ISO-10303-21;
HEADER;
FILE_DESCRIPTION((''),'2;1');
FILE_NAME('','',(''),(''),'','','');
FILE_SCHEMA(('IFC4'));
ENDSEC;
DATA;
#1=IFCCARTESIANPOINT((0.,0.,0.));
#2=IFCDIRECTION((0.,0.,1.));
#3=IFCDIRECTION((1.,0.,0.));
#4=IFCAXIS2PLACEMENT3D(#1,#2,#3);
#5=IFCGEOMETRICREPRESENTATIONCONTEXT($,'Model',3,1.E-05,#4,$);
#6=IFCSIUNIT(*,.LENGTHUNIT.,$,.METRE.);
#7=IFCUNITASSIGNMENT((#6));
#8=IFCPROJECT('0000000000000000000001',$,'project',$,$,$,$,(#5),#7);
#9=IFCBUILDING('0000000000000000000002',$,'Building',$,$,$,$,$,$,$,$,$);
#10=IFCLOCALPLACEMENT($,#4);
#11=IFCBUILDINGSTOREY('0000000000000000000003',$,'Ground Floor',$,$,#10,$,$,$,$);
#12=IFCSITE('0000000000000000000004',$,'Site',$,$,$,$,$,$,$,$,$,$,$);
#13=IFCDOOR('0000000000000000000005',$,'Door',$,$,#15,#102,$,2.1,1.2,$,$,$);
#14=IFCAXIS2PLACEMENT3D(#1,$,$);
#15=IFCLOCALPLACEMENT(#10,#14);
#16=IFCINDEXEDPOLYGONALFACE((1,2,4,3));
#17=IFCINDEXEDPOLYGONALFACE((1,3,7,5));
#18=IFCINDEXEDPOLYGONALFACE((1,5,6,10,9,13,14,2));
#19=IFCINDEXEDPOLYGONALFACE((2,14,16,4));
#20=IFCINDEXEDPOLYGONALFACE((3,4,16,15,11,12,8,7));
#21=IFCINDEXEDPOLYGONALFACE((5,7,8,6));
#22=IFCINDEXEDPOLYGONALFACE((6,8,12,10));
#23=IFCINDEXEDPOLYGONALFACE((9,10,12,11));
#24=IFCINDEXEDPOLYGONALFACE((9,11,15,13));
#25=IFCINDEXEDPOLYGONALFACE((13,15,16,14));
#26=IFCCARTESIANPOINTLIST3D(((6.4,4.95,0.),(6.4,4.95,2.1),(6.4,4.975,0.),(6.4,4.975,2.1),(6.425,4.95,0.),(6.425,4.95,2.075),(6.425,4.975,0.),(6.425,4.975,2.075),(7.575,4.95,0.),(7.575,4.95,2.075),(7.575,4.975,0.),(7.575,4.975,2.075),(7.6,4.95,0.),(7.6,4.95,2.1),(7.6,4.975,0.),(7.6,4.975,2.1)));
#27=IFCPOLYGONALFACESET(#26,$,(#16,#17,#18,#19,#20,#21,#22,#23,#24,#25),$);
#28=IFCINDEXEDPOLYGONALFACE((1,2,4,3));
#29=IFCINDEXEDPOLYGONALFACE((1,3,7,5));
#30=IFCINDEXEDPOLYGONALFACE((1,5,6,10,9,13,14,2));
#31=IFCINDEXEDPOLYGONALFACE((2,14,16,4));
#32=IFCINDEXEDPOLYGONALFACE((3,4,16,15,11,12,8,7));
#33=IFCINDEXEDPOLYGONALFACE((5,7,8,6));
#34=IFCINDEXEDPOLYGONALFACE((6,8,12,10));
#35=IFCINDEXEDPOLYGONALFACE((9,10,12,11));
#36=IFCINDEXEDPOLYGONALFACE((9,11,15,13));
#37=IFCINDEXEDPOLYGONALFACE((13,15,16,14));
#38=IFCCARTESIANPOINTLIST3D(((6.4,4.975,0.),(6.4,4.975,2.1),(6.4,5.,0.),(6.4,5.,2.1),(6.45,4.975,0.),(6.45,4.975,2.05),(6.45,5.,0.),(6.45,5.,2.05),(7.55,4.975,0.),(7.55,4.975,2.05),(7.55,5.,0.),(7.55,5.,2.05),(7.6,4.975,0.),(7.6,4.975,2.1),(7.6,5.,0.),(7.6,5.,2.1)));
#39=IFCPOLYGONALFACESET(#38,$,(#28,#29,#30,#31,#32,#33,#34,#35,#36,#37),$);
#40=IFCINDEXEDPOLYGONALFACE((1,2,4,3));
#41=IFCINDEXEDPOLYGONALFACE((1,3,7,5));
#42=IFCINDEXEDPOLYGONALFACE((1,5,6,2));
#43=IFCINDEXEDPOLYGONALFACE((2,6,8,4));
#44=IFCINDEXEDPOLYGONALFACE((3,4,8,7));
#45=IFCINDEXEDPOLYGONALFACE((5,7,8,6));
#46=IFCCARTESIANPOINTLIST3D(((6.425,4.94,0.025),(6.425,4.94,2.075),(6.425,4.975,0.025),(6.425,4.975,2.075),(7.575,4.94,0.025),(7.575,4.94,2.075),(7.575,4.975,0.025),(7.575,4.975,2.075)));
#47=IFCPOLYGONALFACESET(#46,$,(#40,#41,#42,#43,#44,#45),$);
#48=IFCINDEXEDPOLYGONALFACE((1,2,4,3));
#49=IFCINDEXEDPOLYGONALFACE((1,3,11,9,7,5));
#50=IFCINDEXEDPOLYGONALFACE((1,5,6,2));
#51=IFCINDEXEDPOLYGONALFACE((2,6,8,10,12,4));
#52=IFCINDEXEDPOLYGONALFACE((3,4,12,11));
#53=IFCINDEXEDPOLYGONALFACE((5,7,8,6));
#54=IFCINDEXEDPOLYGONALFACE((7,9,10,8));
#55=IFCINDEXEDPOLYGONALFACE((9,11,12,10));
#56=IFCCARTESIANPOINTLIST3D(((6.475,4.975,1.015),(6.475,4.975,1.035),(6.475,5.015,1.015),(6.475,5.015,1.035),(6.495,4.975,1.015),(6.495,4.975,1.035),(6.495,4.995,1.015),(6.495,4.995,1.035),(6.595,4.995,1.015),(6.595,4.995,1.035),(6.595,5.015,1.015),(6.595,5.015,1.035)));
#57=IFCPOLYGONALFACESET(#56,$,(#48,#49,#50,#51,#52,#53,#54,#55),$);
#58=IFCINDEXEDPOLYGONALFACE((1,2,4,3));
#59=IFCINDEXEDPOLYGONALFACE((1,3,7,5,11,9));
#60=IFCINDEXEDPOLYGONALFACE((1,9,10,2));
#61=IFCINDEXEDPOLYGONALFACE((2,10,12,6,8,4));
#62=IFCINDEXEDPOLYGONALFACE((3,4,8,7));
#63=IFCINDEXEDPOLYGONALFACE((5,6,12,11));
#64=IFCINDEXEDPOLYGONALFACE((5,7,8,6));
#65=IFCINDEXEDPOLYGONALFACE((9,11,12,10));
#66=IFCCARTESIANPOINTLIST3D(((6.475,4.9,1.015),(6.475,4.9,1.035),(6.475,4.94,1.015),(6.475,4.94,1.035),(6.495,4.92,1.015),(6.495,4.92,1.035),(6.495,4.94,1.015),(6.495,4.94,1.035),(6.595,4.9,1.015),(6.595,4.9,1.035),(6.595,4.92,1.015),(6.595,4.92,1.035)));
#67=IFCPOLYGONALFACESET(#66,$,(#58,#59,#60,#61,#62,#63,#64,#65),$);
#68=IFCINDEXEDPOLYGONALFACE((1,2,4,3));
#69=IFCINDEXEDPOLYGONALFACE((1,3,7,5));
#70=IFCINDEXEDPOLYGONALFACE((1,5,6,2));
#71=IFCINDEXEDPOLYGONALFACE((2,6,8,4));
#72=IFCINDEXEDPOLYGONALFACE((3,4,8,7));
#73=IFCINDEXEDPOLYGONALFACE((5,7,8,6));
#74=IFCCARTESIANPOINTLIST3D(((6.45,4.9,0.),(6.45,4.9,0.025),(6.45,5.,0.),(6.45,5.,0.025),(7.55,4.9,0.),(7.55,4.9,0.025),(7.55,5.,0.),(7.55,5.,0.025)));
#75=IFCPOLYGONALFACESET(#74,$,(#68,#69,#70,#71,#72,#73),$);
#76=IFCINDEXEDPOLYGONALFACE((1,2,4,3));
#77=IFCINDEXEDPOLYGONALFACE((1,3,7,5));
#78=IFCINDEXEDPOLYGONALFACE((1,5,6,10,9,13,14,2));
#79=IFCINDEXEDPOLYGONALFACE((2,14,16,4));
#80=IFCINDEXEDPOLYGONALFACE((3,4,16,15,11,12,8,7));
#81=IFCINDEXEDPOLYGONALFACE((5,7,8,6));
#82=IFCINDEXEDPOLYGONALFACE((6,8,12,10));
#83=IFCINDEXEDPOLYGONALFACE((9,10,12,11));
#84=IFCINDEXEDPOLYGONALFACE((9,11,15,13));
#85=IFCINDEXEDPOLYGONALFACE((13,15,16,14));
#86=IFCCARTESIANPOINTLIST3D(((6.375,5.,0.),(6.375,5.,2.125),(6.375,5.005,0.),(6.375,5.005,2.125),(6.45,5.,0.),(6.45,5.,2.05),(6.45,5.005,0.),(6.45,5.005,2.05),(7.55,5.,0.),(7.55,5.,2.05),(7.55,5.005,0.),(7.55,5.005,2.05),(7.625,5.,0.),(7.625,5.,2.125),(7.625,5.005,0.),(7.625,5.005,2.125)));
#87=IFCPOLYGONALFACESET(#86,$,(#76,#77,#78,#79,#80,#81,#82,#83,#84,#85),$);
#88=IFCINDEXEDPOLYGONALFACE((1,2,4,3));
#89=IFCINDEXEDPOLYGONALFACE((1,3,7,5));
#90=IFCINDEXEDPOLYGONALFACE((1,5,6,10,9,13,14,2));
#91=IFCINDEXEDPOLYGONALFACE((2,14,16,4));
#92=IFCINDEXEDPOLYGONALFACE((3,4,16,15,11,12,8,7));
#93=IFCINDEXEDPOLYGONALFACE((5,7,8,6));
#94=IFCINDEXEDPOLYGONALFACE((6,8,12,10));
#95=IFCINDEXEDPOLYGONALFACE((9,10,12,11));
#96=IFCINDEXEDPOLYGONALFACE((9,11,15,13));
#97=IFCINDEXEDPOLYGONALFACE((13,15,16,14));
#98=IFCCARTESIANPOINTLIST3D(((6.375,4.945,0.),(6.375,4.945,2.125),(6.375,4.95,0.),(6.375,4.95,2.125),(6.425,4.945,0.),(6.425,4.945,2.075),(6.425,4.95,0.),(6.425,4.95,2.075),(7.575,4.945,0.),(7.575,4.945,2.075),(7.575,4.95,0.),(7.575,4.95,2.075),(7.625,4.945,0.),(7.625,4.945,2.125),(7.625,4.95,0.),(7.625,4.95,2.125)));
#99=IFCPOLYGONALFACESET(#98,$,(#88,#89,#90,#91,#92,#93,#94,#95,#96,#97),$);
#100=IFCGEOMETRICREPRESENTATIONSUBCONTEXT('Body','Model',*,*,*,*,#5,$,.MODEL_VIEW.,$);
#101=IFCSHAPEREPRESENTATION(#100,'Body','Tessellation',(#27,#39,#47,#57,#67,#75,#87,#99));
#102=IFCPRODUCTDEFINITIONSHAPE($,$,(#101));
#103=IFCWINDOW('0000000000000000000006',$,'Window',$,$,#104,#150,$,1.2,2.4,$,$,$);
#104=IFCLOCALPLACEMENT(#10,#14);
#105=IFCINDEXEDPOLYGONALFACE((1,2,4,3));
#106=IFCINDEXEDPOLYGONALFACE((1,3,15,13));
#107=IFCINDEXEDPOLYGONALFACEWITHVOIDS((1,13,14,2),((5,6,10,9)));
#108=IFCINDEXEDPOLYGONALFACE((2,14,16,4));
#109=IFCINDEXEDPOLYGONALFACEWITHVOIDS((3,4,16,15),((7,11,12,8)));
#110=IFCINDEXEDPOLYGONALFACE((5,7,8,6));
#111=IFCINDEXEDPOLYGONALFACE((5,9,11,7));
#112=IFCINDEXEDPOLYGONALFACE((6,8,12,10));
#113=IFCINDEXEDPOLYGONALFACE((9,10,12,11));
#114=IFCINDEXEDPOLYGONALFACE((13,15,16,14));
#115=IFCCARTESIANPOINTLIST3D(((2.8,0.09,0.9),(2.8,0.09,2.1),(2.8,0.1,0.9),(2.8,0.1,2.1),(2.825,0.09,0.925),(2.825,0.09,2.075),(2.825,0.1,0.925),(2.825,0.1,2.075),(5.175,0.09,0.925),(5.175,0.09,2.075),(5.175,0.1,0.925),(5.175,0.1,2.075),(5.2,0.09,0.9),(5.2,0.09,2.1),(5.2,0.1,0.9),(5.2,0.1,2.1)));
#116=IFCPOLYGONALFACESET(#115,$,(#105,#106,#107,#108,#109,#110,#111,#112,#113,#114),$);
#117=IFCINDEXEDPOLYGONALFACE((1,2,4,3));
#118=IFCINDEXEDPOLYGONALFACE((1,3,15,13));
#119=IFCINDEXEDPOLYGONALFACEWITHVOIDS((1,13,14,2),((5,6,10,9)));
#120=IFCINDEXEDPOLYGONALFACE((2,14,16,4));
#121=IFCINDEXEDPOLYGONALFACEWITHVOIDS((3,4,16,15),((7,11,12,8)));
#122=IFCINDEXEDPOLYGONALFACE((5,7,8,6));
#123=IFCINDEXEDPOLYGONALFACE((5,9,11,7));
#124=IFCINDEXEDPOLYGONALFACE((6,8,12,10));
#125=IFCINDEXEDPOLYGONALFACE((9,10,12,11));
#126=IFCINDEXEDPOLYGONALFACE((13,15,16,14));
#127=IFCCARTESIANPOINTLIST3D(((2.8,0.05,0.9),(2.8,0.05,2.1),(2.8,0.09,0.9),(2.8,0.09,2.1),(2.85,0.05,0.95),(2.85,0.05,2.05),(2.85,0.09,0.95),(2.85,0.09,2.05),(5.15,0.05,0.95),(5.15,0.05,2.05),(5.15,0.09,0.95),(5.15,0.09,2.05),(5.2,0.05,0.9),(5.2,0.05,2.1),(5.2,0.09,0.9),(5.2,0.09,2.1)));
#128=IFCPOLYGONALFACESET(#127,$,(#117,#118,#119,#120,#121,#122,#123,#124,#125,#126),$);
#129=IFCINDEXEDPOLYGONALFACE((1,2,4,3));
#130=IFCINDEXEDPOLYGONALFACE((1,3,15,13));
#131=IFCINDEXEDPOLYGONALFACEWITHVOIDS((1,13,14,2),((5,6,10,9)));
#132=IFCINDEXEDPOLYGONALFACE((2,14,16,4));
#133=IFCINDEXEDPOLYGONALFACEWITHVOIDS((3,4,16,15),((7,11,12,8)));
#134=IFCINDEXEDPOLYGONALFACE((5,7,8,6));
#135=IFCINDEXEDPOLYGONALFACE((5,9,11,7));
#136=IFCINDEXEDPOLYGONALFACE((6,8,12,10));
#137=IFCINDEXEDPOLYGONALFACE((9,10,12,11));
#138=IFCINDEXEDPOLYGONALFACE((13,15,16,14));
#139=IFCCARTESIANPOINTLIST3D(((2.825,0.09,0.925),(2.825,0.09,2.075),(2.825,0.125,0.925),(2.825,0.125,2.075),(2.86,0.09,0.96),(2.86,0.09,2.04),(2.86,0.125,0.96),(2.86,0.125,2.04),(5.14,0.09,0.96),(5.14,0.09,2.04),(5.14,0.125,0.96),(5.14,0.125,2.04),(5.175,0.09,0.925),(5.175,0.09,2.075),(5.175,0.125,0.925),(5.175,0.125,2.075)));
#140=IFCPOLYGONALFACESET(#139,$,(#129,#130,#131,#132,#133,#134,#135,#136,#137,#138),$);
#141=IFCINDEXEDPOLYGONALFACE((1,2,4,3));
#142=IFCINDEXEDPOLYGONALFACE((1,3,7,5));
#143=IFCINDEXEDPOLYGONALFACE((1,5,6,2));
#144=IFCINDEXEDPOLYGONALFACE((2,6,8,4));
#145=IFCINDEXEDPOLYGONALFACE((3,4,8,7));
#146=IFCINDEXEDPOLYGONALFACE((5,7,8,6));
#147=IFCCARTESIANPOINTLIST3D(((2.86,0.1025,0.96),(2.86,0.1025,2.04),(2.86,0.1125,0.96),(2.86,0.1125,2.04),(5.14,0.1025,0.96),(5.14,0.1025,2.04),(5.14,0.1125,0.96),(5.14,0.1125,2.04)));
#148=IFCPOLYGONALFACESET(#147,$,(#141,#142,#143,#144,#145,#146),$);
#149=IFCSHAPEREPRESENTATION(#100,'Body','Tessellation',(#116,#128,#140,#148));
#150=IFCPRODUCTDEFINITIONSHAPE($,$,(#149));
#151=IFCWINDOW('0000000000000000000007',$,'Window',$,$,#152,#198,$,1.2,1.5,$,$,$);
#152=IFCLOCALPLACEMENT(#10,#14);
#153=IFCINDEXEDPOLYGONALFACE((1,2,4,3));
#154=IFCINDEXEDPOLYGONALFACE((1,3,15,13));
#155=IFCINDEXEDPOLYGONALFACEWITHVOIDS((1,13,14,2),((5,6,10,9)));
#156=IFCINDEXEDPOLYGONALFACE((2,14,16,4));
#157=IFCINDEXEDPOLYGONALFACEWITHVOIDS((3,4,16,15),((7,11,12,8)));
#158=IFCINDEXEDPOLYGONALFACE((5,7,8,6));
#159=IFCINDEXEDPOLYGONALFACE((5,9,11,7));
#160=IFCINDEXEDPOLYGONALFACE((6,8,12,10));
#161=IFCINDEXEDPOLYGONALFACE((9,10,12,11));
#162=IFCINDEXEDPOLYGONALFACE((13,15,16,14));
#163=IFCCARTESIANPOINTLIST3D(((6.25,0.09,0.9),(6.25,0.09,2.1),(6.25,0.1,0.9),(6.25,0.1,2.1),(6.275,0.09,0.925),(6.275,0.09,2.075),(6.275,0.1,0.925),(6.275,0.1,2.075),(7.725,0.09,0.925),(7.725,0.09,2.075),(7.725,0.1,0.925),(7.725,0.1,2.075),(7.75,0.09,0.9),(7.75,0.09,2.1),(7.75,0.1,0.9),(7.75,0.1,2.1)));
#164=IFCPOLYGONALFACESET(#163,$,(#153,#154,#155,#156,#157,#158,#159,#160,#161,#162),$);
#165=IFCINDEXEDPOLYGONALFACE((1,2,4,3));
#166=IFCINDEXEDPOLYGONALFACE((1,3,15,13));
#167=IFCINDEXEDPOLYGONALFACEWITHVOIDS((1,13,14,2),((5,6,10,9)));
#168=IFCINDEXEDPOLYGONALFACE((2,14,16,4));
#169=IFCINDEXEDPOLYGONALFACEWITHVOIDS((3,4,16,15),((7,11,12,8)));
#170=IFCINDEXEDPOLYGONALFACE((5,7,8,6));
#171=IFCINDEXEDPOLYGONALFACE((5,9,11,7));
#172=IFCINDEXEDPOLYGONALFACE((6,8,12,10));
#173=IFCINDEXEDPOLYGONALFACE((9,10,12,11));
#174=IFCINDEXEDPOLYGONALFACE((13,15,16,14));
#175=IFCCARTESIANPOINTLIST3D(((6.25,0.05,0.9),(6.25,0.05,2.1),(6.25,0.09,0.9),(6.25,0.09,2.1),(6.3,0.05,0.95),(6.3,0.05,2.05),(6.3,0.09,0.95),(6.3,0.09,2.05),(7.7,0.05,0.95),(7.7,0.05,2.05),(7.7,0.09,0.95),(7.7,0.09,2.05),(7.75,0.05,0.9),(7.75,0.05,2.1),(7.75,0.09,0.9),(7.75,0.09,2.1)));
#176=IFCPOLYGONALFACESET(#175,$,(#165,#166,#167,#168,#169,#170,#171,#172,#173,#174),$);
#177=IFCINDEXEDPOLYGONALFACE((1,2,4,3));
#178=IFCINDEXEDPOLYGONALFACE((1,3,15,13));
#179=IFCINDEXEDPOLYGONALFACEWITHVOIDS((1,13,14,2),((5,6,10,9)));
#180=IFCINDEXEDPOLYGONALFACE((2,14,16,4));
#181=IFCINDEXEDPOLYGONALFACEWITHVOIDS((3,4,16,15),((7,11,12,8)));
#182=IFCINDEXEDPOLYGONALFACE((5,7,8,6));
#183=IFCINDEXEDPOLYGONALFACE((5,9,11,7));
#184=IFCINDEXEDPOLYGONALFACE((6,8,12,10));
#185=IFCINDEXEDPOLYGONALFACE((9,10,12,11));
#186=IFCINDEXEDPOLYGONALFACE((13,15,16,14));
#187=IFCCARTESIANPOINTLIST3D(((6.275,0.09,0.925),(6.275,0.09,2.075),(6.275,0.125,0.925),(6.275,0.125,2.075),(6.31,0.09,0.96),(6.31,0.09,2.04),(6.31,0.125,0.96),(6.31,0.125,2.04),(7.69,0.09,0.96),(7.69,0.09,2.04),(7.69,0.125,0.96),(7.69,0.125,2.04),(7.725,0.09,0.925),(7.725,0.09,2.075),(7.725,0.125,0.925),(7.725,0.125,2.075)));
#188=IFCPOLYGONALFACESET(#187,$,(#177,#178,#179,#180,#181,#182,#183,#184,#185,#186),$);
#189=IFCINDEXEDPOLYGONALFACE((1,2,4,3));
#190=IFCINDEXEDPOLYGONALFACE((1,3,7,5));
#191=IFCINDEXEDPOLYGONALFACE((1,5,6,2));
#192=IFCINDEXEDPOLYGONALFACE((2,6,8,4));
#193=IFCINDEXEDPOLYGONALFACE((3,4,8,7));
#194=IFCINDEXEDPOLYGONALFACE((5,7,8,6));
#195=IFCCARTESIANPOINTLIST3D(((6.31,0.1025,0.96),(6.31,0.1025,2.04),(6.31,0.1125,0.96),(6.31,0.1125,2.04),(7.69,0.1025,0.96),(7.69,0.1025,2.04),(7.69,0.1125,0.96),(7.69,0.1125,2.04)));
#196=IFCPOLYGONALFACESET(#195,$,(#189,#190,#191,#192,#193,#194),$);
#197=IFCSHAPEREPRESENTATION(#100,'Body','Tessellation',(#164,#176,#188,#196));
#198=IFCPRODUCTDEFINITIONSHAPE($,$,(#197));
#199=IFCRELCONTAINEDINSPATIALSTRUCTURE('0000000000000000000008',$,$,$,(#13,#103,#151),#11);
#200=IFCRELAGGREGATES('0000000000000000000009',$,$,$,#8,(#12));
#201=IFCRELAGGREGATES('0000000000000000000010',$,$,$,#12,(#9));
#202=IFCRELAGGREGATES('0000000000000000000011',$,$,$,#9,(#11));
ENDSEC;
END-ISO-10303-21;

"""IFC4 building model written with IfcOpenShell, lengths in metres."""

from ifc_helpers import new_model, si_unit, frame, origin_with_axes, place, context, subcontext, project, spatial, line, indexed_curve, outline, extrude, element, save


model = new_model("IFC4")

# Units and contexts
model_context = context("Model", 3, precision=1e-05, world=origin_with_axes())
body_context = subcontext(model_context, "Body", "Model", "MODEL_VIEW")
ifc_project = project(units=[si_unit("LENGTHUNIT", "METRE")], contexts=[model_context])

# Site, building, storey
site = spatial("IfcSite", under=ifc_project, Name="Site")
building = spatial("IfcBuilding", under=site, Name="Building")
storey_placement = place(None, origin_with_axes())
storey = spatial("IfcBuildingStorey", under=building, at=storey_placement, Name="Ground Floor")

# Door
door_1_placement = place(storey_placement, frame((7.6, 5.0, 0.0), z_axis=(0.0, 0.0, 1.0), x_axis=(-1.0, 0.0, 0.0)))
element("IfcDoor", 1, at=door_1_placement, inside=storey, Name="Door", OverallHeight=2.1, OverallWidth=1.2, context=body_context, shape_type="SweptSolid", body=[
    extrude(outline(indexed_curve([(0.0, 0.0), (0.0, 2.1), (1.2, 2.1), (1.2, 0.0), (1.175, 0.0), (1.175, 2.075), (0.025, 2.075), (0.025, 0.0)], segments=[line(1, 2, 3, 4, 5, 6, 7, 8, 1)])), frame((0.0, 0.025, 0.0), z_axis=(0.0, -1.0, 0.0), x_axis=(1.0, 0.0, 0.0)), (0.0, 0.0, -1.0), 0.025),
    extrude(outline(indexed_curve([(0.0, 0.0), (0.0, 2.1), (1.2, 2.1), (1.2, 0.0), (1.15, 0.0), (1.15, 2.05), (0.05, 2.05), (0.05, 0.0)], segments=[line(1, 2, 3, 4, 5, 6, 7, 8, 1)])), frame((0.0, 0.0, 0.0), z_axis=(0.0, -1.0, 0.0), x_axis=(1.0, 0.0, 0.0)), (0.0, 0.0, -1.0), 0.025),
    extrude(outline(indexed_curve([(0.0, 0.0), (1.15, 0.0), (1.15, 0.035), (0.0, 0.035)], segments=[line(1, 2, 3, 4, 1)])), frame((0.025, 0.025, 0.025), z_axis=(0.0, 0.0, 1.0), x_axis=(1.0, 0.0, 0.0)), (0.0, 0.0, 1.0), 2.05),
    extrude(outline(indexed_curve([(0.0, 0.0), (0.0, -0.04), (-0.12, -0.04), (-0.12, -0.02), (-0.02, -0.02), (-0.02, 0.0)], segments=[line(1, 2, 3, 4, 5, 6, 1)])), frame((1.125, 0.025, 1.015), z_axis=(0.0, 0.0, 1.0), x_axis=(1.0, 0.0, 0.0)), (0.0, 0.0, 1.0), 0.02),
    extrude(outline(indexed_curve([(0.0, 0.0), (0.0, 0.04), (-0.12, 0.04), (-0.12, 0.02), (-0.02, 0.02), (-0.02, 0.0)], segments=[line(1, 2, 3, 4, 5, 6, 1)])), frame((1.125, 0.06, 1.015), z_axis=(0.0, 0.0, 1.0), x_axis=(1.0, 0.0, 0.0)), (0.0, 0.0, 1.0), 0.02),
    extrude(outline(indexed_curve([(0.0, 0.0), (1.1, 0.0), (1.1, 0.1), (0.0, 0.1)], segments=[line(1, 2, 3, 4, 1)])), frame((0.05, 0.0, 0.0), z_axis=(0.0, 0.0, 1.0), x_axis=(1.0, 0.0, 0.0)), (0.0, 0.0, 1.0), 0.025),
    extrude(outline(indexed_curve([(0.0, 0.0), (0.0, 2.125), (1.25, 2.125), (1.25, 0.0), (1.175, 0.0), (1.175, 2.05), (0.075, 2.05), (0.075, 0.0)], segments=[line(1, 2, 3, 4, 5, 6, 7, 8, 1)])), frame((-0.025, -0.005, 0.0), z_axis=(0.0, -1.0, 0.0), x_axis=(1.0, 0.0, 0.0)), (0.0, 0.0, -1.0), 0.005),
    extrude(outline(indexed_curve([(0.0, 0.0), (0.0, 2.125), (1.25, 2.125), (1.25, 0.0), (1.2, 0.0), (1.2, 2.075), (0.05, 2.075), (0.05, 0.0)], segments=[line(1, 2, 3, 4, 5, 6, 7, 8, 1)])), frame((-0.025, 0.05, 0.0), z_axis=(0.0, -1.0, 0.0), x_axis=(1.0, 0.0, 0.0)), (0.0, 0.0, -1.0), 0.005),
])

# Windows
window_1_placement = place(storey_placement, frame((2.8, 0.0, 0.9), z_axis=(0.0, 0.0, 1.0), x_axis=(1.0, 0.0, 0.0)))
element("IfcWindow", 2, at=window_1_placement, inside=storey, Name="Window", OverallHeight=1.2, OverallWidth=2.4, context=body_context, shape_type="SweptSolid", body=[
    extrude(outline(indexed_curve([(0.0, 0.0), (2.4, 0.0), (2.4, 1.2), (0.0, 1.2)], segments=[line(1, 2, 3, 4, 1)]), holes=[indexed_curve([(0.025, 0.025), (2.375, 0.025), (2.375, 1.175), (0.025, 1.175)], segments=[line(1, 2, 3, 4, 1)])]), frame((0.0, 0.09, 0.0), z_axis=(0.0, -1.0, 0.0), x_axis=(1.0, 0.0, 0.0)), (0.0, 0.0, -1.0), 0.01),
    extrude(outline(indexed_curve([(0.0, 0.0), (2.4, 0.0), (2.4, 1.2), (0.0, 1.2)], segments=[line(1, 2, 3, 4, 1)]), holes=[indexed_curve([(0.05, 0.05), (2.35, 0.05), (2.35, 1.15), (0.05, 1.15)], segments=[line(1, 2, 3, 4, 1)])]), frame((0.0, 0.05, 0.0), z_axis=(0.0, -1.0, 0.0), x_axis=(1.0, 0.0, 0.0)), (0.0, 0.0, -1.0), 0.04),
    extrude(outline(indexed_curve([(0.0, 0.0), (2.35, 0.0), (2.35, 1.15), (0.0, 1.15)], segments=[line(1, 2, 3, 4, 1)]), holes=[indexed_curve([(0.035, 0.035), (2.315, 0.035), (2.315, 1.115), (0.035, 1.115)], segments=[line(1, 2, 3, 4, 1)])]), frame((0.025, 0.09, 0.025), z_axis=(0.0, -1.0, 0.0), x_axis=(1.0, 0.0, 0.0)), (0.0, 0.0, -1.0), 0.035),
    extrude(outline(indexed_curve([(0.035, 0.035), (2.315, 0.035), (2.315, 1.115), (0.035, 1.115)], segments=[line(1, 2, 3, 4, 1)])), frame((0.025, 0.1025, 0.025), z_axis=(0.0, -1.0, 0.0), x_axis=(1.0, 0.0, 0.0)), (0.0, 0.0, -1.0), 0.01),
])
for number, where, z_axis, x_axis, name in (
    (3, (6.25, 0.0, 0.9), (0.0, 0.0, 1.0), (1.0, 0.0, 0.0), "Window"),
):
    element("IfcWindow", number, at=place(storey_placement, frame(where, z_axis=z_axis, x_axis=x_axis)), inside=storey, Name=name, OverallHeight=1.2, OverallWidth=1.5, context=body_context, shape_type="SweptSolid", body=[
        extrude(outline(indexed_curve([(0.0, 0.0), (1.5, 0.0), (1.5, 1.2), (0.0, 1.2)], segments=[line(1, 2, 3, 4, 1)]), holes=[indexed_curve([(0.025, 0.025), (1.475, 0.025), (1.475, 1.175), (0.025, 1.175)], segments=[line(1, 2, 3, 4, 1)])]), frame((0.0, 0.09, 0.0), z_axis=(0.0, -1.0, 0.0), x_axis=(1.0, 0.0, 0.0)), (0.0, 0.0, -1.0), 0.01),
        extrude(outline(indexed_curve([(0.0, 0.0), (1.5, 0.0), (1.5, 1.2), (0.0, 1.2)], segments=[line(1, 2, 3, 4, 1)]), holes=[indexed_curve([(0.05, 0.05), (1.45, 0.05), (1.45, 1.15), (0.05, 1.15)], segments=[line(1, 2, 3, 4, 1)])]), frame((0.0, 0.05, 0.0), z_axis=(0.0, -1.0, 0.0), x_axis=(1.0, 0.0, 0.0)), (0.0, 0.0, -1.0), 0.04),
        extrude(outline(indexed_curve([(0.0, 0.0), (1.45, 0.0), (1.45, 1.15), (0.0, 1.15)], segments=[line(1, 2, 3, 4, 1)]), holes=[indexed_curve([(0.035, 0.035), (1.415, 0.035), (1.415, 1.115), (0.035, 1.115)], segments=[line(1, 2, 3, 4, 1)])]), frame((0.025, 0.09, 0.025), z_axis=(0.0, -1.0, 0.0), x_axis=(1.0, 0.0, 0.0)), (0.0, 0.0, -1.0), 0.035),
        extrude(outline(indexed_curve([(0.035, 0.035), (1.415, 0.035), (1.415, 1.115), (0.035, 1.115)], segments=[line(1, 2, 3, 4, 1)])), frame((0.025, 0.1025, 0.025), z_axis=(0.0, -1.0, 0.0), x_axis=(1.0, 0.0, 0.0)), (0.0, 0.0, -1.0), 0.01),
    ])

save(model, "model.ifc")
